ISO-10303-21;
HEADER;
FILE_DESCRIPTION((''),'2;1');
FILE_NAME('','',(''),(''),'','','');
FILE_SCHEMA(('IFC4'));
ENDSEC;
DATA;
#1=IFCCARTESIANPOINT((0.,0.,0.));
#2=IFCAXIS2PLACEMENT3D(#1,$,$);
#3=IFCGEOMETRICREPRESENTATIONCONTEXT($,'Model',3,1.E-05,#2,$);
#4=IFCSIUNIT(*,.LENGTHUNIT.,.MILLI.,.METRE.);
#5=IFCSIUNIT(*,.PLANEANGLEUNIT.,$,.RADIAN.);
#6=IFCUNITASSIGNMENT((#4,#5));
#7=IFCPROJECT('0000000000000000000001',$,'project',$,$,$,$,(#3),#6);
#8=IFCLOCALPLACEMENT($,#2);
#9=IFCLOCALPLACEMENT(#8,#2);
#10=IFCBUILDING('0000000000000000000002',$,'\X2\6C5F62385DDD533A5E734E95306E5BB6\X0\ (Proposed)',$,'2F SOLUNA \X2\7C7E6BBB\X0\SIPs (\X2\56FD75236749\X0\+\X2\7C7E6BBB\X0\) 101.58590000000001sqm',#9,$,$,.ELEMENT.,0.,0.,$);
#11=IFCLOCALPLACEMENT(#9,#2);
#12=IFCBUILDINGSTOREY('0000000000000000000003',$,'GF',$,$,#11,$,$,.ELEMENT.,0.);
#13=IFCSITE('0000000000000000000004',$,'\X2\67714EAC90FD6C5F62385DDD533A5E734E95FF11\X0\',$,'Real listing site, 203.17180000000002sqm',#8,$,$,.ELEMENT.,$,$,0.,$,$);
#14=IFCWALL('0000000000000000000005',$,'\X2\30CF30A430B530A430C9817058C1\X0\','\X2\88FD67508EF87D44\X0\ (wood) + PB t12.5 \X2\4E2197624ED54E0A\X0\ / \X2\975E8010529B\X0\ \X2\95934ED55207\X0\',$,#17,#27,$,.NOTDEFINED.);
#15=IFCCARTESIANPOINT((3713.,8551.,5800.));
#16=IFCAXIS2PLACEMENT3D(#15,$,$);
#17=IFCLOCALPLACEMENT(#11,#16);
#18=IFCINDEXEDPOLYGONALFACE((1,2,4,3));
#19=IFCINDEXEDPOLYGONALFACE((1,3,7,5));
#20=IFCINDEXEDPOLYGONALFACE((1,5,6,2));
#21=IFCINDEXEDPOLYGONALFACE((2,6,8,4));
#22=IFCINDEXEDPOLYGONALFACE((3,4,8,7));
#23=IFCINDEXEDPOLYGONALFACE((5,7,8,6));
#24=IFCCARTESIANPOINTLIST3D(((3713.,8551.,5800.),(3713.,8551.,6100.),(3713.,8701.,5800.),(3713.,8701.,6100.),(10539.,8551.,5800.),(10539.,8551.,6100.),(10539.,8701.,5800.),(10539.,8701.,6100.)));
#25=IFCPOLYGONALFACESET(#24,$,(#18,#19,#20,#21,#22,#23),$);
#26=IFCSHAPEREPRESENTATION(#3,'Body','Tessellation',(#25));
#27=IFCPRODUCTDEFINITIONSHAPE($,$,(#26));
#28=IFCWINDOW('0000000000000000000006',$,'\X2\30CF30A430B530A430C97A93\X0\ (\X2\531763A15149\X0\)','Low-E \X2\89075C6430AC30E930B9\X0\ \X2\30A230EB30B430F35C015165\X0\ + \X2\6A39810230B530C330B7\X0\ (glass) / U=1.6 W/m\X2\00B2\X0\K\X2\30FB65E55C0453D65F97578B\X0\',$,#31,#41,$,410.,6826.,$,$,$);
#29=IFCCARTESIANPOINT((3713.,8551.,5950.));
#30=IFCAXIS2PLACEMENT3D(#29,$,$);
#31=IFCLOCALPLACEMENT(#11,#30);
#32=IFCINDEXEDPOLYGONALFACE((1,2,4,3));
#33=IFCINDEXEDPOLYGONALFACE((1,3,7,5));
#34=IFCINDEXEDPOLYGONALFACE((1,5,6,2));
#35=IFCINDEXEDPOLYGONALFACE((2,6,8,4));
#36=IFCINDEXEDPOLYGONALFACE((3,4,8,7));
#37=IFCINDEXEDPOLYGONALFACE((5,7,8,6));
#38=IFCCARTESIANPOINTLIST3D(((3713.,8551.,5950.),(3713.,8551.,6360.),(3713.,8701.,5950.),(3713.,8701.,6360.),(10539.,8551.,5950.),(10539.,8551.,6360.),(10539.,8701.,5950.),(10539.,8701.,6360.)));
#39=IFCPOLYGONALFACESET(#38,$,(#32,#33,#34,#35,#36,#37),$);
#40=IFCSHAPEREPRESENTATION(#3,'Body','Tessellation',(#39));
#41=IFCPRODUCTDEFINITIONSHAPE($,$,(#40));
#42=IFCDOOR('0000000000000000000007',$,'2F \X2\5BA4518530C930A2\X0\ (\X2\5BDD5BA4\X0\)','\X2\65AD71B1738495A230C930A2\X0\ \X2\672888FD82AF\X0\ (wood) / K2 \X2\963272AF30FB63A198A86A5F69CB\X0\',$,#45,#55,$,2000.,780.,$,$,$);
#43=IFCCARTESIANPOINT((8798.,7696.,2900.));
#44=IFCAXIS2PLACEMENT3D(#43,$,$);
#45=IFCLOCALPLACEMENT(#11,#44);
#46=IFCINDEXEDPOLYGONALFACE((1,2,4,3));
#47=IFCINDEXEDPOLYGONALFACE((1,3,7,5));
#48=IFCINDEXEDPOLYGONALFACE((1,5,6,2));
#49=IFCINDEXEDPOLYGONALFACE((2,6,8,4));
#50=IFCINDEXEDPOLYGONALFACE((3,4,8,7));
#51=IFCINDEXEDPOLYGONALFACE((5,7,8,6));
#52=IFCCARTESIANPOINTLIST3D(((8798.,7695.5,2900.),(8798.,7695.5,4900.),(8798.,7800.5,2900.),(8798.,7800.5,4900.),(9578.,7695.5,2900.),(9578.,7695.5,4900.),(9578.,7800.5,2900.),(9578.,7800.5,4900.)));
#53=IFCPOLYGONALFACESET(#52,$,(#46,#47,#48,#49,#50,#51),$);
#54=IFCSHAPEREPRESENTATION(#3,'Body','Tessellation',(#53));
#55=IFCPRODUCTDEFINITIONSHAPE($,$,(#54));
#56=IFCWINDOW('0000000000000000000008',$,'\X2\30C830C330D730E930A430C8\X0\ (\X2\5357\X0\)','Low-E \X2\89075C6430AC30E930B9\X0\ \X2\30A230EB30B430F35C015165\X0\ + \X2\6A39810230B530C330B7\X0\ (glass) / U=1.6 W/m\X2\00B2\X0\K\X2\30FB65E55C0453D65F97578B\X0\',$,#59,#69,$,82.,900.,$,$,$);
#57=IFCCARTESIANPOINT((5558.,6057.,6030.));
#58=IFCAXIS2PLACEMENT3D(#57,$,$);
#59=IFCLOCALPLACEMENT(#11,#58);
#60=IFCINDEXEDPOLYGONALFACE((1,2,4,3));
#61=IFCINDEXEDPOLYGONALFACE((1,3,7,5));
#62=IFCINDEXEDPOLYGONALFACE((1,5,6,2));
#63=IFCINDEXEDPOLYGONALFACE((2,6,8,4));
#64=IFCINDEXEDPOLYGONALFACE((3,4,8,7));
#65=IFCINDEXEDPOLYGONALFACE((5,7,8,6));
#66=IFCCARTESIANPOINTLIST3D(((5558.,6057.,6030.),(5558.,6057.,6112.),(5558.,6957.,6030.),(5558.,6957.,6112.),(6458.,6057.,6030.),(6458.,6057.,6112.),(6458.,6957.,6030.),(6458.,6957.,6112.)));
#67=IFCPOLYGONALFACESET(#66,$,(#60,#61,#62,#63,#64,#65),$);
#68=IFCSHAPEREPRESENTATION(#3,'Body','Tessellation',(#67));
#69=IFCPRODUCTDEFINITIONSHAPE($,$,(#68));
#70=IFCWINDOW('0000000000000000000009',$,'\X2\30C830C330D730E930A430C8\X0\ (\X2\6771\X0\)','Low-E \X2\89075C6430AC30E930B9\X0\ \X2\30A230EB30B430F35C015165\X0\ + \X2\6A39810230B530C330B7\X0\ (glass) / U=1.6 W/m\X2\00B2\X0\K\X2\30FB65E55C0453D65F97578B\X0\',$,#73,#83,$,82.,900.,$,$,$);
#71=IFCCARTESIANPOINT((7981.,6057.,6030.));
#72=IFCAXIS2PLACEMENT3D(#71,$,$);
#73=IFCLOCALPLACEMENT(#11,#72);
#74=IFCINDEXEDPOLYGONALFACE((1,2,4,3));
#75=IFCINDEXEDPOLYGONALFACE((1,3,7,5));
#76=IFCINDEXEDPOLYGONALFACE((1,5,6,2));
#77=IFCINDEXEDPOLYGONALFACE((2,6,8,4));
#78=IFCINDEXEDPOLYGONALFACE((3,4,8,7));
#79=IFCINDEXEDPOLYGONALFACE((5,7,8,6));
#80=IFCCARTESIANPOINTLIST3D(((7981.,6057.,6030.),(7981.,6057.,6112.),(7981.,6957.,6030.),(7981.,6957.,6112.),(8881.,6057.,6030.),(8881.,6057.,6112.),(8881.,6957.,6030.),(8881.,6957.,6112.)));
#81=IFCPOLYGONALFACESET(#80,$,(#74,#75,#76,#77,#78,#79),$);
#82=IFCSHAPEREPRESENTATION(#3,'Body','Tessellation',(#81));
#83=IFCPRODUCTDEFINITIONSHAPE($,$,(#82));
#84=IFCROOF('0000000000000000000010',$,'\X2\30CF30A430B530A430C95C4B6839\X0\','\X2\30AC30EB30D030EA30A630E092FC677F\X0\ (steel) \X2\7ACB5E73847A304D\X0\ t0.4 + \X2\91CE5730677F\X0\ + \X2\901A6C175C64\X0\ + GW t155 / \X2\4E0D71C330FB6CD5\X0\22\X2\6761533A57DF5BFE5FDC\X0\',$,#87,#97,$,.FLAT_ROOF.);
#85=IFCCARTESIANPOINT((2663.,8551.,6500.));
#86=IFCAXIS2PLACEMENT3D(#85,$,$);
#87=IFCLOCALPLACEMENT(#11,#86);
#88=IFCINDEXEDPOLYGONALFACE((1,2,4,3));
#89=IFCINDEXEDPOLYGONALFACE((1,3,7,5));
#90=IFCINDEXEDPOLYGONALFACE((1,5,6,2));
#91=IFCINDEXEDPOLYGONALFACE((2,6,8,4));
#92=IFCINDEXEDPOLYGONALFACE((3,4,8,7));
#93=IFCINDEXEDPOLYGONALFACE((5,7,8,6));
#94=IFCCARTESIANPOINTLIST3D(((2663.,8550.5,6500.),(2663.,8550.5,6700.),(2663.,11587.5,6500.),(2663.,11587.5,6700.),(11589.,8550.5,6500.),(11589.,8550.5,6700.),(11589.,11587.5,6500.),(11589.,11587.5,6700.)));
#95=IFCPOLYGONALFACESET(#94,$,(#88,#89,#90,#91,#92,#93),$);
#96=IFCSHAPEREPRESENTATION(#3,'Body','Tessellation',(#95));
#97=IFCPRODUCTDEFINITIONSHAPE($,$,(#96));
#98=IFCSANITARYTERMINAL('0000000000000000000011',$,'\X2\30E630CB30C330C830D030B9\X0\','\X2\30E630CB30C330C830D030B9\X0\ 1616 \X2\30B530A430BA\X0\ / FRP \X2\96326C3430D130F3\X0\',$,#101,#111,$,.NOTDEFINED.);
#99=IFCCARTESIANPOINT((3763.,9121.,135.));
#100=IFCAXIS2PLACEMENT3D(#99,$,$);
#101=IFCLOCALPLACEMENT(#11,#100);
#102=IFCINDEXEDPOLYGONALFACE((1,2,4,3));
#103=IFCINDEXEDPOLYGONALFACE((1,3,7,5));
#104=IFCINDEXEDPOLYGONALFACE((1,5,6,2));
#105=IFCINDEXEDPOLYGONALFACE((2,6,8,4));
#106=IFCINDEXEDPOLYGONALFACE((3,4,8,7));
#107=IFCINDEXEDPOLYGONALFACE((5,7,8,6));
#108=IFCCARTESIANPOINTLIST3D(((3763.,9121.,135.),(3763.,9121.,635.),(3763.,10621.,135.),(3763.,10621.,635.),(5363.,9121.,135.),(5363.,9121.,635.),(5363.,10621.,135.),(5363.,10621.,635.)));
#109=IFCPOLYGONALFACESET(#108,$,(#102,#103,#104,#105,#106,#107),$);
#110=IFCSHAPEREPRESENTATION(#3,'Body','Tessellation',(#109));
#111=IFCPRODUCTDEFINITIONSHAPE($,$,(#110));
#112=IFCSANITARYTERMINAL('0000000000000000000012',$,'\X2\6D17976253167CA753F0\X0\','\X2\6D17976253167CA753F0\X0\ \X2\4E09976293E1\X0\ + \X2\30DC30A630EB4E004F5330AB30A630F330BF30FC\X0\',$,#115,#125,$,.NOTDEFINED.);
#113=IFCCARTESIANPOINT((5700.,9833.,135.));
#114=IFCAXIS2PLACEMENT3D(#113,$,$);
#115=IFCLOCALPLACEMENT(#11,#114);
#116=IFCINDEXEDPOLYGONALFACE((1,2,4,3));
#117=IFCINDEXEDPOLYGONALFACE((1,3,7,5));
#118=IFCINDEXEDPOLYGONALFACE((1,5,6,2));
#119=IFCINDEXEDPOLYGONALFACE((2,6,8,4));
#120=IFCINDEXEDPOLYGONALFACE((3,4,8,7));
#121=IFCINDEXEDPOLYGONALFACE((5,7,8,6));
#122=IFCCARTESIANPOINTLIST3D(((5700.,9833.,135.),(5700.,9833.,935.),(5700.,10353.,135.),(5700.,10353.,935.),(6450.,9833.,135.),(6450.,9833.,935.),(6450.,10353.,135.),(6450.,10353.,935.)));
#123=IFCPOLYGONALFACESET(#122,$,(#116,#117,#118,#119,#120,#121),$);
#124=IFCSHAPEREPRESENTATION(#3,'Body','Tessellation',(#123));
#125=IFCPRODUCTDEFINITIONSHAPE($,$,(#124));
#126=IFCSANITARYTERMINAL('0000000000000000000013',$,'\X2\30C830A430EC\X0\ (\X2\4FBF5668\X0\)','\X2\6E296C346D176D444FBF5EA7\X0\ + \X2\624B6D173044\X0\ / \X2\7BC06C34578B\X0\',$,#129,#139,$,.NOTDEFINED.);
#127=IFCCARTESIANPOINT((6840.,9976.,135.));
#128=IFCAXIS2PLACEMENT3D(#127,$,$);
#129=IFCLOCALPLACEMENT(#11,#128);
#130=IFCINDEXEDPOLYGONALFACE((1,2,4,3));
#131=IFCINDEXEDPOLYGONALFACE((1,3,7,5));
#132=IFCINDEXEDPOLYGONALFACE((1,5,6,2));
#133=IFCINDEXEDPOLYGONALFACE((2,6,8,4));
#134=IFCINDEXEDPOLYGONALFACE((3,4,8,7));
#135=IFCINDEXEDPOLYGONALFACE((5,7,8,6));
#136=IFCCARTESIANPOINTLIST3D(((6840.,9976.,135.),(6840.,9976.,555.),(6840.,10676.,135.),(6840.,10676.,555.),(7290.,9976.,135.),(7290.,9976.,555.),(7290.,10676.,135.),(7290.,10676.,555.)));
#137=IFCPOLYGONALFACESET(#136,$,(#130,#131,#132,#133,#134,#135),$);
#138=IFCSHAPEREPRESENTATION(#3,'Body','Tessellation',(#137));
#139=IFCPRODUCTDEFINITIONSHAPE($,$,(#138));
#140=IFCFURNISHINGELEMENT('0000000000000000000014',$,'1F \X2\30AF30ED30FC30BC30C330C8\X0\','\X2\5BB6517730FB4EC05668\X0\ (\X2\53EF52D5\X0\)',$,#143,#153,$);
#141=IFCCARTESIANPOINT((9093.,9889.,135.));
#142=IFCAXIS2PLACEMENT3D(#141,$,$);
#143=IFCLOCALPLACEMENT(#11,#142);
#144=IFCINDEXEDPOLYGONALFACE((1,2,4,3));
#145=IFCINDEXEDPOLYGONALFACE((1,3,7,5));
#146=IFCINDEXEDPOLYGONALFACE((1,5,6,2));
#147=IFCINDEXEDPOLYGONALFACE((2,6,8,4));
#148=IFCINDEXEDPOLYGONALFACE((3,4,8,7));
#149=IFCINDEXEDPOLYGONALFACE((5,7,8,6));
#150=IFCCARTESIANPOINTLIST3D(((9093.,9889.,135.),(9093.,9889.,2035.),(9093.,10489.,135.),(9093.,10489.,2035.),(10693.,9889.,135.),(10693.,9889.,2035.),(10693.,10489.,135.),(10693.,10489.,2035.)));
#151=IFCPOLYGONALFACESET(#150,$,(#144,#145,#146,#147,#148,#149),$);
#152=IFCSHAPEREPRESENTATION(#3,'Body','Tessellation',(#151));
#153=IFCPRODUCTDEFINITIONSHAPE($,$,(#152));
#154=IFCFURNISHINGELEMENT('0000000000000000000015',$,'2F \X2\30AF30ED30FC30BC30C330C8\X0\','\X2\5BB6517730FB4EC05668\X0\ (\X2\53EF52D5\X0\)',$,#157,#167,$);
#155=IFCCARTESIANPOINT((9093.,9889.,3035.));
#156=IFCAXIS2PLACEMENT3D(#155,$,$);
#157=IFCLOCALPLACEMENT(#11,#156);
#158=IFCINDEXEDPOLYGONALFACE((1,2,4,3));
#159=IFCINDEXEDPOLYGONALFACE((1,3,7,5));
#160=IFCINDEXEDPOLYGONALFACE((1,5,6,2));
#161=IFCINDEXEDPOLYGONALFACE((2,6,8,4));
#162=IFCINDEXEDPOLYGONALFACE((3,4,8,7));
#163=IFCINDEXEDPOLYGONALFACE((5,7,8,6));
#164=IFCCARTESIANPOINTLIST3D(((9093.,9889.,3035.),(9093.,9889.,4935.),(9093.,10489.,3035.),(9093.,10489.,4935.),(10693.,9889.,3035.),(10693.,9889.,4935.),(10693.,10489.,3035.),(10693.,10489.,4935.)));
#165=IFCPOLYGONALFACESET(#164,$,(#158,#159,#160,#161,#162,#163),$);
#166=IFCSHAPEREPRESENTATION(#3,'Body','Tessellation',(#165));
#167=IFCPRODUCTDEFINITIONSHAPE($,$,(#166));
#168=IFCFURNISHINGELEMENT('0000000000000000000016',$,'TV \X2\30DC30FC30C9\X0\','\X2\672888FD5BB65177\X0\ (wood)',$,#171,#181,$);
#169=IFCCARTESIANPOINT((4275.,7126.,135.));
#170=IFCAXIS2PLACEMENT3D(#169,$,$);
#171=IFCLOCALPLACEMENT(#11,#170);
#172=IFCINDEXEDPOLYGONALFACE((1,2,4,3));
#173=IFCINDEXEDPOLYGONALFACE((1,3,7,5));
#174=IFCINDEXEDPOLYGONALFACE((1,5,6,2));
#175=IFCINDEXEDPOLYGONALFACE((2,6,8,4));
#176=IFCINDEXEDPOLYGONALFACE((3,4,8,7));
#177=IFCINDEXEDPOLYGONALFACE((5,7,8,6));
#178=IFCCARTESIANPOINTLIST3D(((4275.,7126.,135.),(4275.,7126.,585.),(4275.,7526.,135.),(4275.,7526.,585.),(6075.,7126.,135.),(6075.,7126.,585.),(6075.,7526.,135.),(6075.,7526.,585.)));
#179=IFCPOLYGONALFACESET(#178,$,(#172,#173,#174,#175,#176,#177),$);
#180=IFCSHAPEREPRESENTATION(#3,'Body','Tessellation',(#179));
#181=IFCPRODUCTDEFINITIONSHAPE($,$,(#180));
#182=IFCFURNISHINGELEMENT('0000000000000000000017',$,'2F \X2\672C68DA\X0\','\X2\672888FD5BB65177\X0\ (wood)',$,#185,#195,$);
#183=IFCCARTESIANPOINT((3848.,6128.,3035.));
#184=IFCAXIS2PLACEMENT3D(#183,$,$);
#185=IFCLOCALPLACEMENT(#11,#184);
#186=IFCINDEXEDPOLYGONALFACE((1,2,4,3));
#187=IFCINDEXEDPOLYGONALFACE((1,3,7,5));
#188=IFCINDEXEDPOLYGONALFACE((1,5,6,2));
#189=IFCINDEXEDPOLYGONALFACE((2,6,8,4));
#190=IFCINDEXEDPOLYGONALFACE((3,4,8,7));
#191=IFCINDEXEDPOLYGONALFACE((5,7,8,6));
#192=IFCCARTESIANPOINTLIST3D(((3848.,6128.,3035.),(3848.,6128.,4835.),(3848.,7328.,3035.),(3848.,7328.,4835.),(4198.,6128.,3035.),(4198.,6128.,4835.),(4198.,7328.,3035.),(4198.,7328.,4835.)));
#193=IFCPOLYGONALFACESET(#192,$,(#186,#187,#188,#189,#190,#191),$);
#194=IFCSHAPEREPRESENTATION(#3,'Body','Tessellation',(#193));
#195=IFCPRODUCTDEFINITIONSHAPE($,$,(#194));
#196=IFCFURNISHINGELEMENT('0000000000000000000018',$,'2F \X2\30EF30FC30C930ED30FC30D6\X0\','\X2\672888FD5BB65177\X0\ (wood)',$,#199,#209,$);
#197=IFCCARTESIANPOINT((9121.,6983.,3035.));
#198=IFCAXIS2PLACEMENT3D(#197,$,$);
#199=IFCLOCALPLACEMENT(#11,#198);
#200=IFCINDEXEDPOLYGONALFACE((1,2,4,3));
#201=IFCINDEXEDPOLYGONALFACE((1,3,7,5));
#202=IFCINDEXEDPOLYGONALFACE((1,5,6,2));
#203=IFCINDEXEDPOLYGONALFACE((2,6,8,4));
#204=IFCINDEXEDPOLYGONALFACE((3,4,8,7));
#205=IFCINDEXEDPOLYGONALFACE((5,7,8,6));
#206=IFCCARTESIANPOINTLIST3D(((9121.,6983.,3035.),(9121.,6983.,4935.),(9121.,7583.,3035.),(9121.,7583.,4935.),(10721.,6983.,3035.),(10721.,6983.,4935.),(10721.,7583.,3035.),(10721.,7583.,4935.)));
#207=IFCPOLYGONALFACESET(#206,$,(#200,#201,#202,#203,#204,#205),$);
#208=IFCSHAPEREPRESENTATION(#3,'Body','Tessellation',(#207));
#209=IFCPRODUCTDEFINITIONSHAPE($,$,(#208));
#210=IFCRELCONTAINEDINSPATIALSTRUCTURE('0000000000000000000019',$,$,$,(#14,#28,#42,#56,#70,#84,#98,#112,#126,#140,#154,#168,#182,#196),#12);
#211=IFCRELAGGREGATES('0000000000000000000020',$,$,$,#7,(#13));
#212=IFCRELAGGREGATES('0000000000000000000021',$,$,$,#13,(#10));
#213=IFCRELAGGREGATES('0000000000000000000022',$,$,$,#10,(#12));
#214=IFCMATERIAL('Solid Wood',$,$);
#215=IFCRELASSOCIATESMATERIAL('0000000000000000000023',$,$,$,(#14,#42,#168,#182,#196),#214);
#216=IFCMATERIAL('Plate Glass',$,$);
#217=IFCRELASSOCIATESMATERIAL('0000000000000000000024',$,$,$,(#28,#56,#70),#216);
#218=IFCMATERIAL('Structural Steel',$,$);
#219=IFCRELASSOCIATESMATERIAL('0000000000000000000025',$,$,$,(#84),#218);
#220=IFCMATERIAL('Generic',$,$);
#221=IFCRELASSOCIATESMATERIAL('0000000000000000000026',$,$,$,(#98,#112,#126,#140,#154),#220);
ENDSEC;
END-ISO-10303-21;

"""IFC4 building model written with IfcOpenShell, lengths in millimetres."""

from ifc_helpers import new_model, si_unit, frame, frame_2d, origin, place, context, project, spatial, rectangle, extrude, material, element, fill, save


model = new_model("IFC4")

# Units and contexts
model_context = context("Model", 3, precision=1e-05, world=origin())
ifc_project = project(units=[si_unit("LENGTHUNIT", "METRE", prefix="MILLI"), si_unit("PLANEANGLEUNIT", "RADIAN")], contexts=[model_context])

# Site, building, storey
site_placement = place(None, origin())
site = spatial("IfcSite", under=ifc_project, at=site_placement, Name="東京都江戸川区平井１", ObjectType="Real listing site, 203.17180000000002sqm", CompositionType="ELEMENT", RefElevation=0.0)
building_placement = place(site_placement, origin())
building = spatial("IfcBuilding", under=site, at=building_placement, Name="江戸川区平井の家 (Proposed)", ObjectType="2F SOLUNA 籾殻SIPs (国産杉+籾殻) 101.58590000000001sqm", CompositionType="ELEMENT", ElevationOfRefHeight=0.0, ElevationOfTerrain=0.0)
storey_placement = place(building_placement, origin())
storey = spatial("IfcBuildingStorey", under=building, at=storey_placement, Name="GF", CompositionType="ELEMENT", Elevation=0.0)

# Shared definitions
ifc_material_1 = material(Name="Solid Wood")
ifc_material_2 = material(Name="Plate Glass")

# Wall, opening, window
wall_1_placement = place(storey_placement, frame((3713.0, 8551.0, 5800.0)))
wall_1 = element("IfcWall", 1, at=wall_1_placement, inside=storey, material=ifc_material_1, Name="ハイサイド腰壁", Description="製材軸組 (wood) + PB t12.5 両面仕上 / 非耐力 間仕切", PredefinedType="NOTDEFINED", context=model_context, shape_type="SweptSolid", body=[
    extrude(rectangle(XDim=6826.0, YDim=150.0, at=frame_2d((3413.0, 75.0))), frame((3713.0, 8551.0, 5800.0)), (0.0, 0.0, 1.0), 700.0),
])
opening_1_placement = place(storey_placement, frame((3713.0, 8551.0, 5950.0)))
opening_1 = element("IfcOpeningElement", 2, at=opening_1_placement, cuts=wall_1, PredefinedType="NOTDEFINED", context=model_context, shape_type="SweptSolid", body=[
    extrude(rectangle(XDim=6826.0, YDim=150.0, at=frame_2d((3413.0, 75.0))), frame((3713.0, 8551.0, 5950.0)), (0.0, 0.0, 1.0), 410.0),
])
window_1_placement = place(storey_placement, frame((3713.0, 8551.0, 5950.0)))
window_1 = element("IfcWindow", 3, at=window_1_placement, inside=storey, material=ifc_material_2, Name="ハイサイド窓 (北採光)", Description="Low-E 複層ガラス アルゴン封入 + 樹脂サッシ (glass) / U=1.6 W/m²K・日射取得型", OverallHeight=410.0, OverallWidth=6826.0, context=model_context, shape_type="SweptSolid", body=[
    extrude(rectangle(XDim=6826.0, YDim=150.0, at=frame_2d((3413.0, 75.0))), frame((3713.0, 8551.0, 5950.0)), (0.0, 0.0, 1.0), 410.0),
])
fill(opening_1, window_1)

# Door
door_1_placement = place(storey_placement, frame((8798.0, 7696.0, 2900.0)))
element("IfcDoor", 4, at=door_1_placement, inside=storey, material=ifc_material_1, Name="2F 室内ドア (寝室)", Description="断熱玄関ドア 木製芯 (wood) / K2 防犯・採風機構", OverallHeight=2000.0, OverallWidth=780.0, context=model_context, shape_type="SweptSolid", body=[
    extrude(rectangle(XDim=780.0, YDim=105.0, at=frame_2d((390.0, 52.0))), frame((8798.0, 7696.0, 2900.0)), (0.0, 0.0, 1.0), 2000.0),
])

# Windows
window_2_placement = place(storey_placement, frame((5558.0, 6057.0, 6030.0)))
element("IfcWindow", 5, at=window_2_placement, inside=storey, material=ifc_material_2, Name="トップライト (南)", Description="Low-E 複層ガラス アルゴン封入 + 樹脂サッシ (glass) / U=1.6 W/m²K・日射取得型", OverallHeight=82.0, OverallWidth=900.0, context=model_context, shape_type="SweptSolid", body=[
    extrude(rectangle(XDim=900.0, YDim=900.0, at=frame_2d((450.0, 450.0))), frame((5558.0, 6057.0, 6030.0)), (0.0, 0.0, 1.0), 82.0),
])
window_3_placement = place(storey_placement, frame((7981.0, 6057.0, 6030.0)))
element("IfcWindow", 6, at=window_3_placement, inside=storey, material=ifc_material_2, Name="トップライト (東)", Description="Low-E 複層ガラス アルゴン封入 + 樹脂サッシ (glass) / U=1.6 W/m²K・日射取得型", OverallHeight=82.0, OverallWidth=900.0, context=model_context, shape_type="SweptSolid", body=[
    extrude(rectangle(XDim=900.0, YDim=900.0, at=frame_2d((450.0, 450.0))), frame((7981.0, 6057.0, 6030.0)), (0.0, 0.0, 1.0), 82.0),
])

# Roof
ifc_material_3 = material(Name="Structural Steel")
roof_placement = place(storey_placement, frame((2663.0, 8551.0, 6500.0)))
element("IfcRoof", 7, at=roof_placement, inside=storey, material=ifc_material_3, Name="ハイサイド屋根", Description="ガルバリウム鋼板 (steel) 立平葺き t0.4 + 野地板 + 通気層 + GW t155 / 不燃・法22条区域対応", PredefinedType="FLAT_ROOF", context=model_context, shape_type="SweptSolid", body=[
    extrude(rectangle(XDim=8926.0, YDim=3037.0, at=frame_2d((4463.0, 1518.0))), frame((2663.0, 8551.0, 6500.0)), (0.0, 0.0, 1.0), 200.0),
])

# Sanitary terminals
ifc_material_4 = material(Name="Generic")
sanitary_terminal_1_placement = place(storey_placement, frame((3763.0, 9121.0, 135.0)))
element("IfcSanitaryTerminal", 8, at=sanitary_terminal_1_placement, inside=storey, material=ifc_material_4, Name="ユニットバス", Description="ユニットバス 1616 サイズ / FRP 防水パン", PredefinedType="NOTDEFINED", context=model_context, shape_type="SweptSolid", body=[
    extrude(rectangle(XDim=1600.0, YDim=1500.0, at=frame_2d((800.0, 750.0))), frame((3763.0, 9121.0, 135.0)), (0.0, 0.0, 1.0), 500.0),
])
sanitary_terminal_2_placement = place(storey_placement, frame((5700.0, 9833.0, 135.0)))
element("IfcSanitaryTerminal", 9, at=sanitary_terminal_2_placement, inside=storey, material=ifc_material_4, Name="洗面化粧台", Description="洗面化粧台 三面鏡 + ボウル一体カウンター", PredefinedType="NOTDEFINED", context=model_context, shape_type="SweptSolid", body=[
    extrude(rectangle(XDim=750.0, YDim=520.0, at=frame_2d((375.0, 260.0))), frame((5700.0, 9833.0, 135.0)), (0.0, 0.0, 1.0), 800.0),
])
sanitary_terminal_3_placement = place(storey_placement, frame((6840.0, 9976.0, 135.0)))
element("IfcSanitaryTerminal", 10, at=sanitary_terminal_3_placement, inside=storey, material=ifc_material_4, Name="トイレ (便器)", Description="温水洗浄便座 + 手洗い / 節水型", PredefinedType="NOTDEFINED", context=model_context, shape_type="SweptSolid", body=[
    extrude(rectangle(XDim=450.0, YDim=700.0, at=frame_2d((225.0, 350.0))), frame((6840.0, 9976.0, 135.0)), (0.0, 0.0, 1.0), 420.0),
])

# Furnishing elements
furnishing_1_placement = place(storey_placement, frame((9093.0, 9889.0, 135.0)))
element("IfcFurnishingElement", 11, at=furnishing_1_placement, inside=storey, material=ifc_material_4, Name="1F クローゼット", Description="家具・什器 (可動)", context=model_context, shape_type="SweptSolid", body=[
    extrude(rectangle(XDim=1600.0, YDim=600.0, at=frame_2d((800.0, 300.0))), frame((9093.0, 9889.0, 135.0)), (0.0, 0.0, 1.0), 1900.0),
])
furnishing_2_placement = place(storey_placement, frame((9093.0, 9889.0, 3035.0)))
element("IfcFurnishingElement", 12, at=furnishing_2_placement, inside=storey, material=ifc_material_4, Name="2F クローゼット", Description="家具・什器 (可動)", context=model_context, shape_type="SweptSolid", body=[
    extrude(rectangle(XDim=1600.0, YDim=600.0, at=frame_2d((800.0, 300.0))), frame((9093.0, 9889.0, 3035.0)), (0.0, 0.0, 1.0), 1900.0),
])
furnishing_3_placement = place(storey_placement, frame((4275.0, 7126.0, 135.0)))
element("IfcFurnishingElement", 13, at=furnishing_3_placement, inside=storey, material=ifc_material_1, Name="TV ボード", Description="木製家具 (wood)", context=model_context, shape_type="SweptSolid", body=[
    extrude(rectangle(XDim=1800.0, YDim=400.0, at=frame_2d((900.0, 200.0))), frame((4275.0, 7126.0, 135.0)), (0.0, 0.0, 1.0), 450.0),
])
furnishing_4_placement = place(storey_placement, frame((3848.0, 6128.0, 3035.0)))
element("IfcFurnishingElement", 14, at=furnishing_4_placement, inside=storey, material=ifc_material_1, Name="2F 本棚", Description="木製家具 (wood)", context=model_context, shape_type="SweptSolid", body=[
    extrude(rectangle(XDim=350.0, YDim=1200.0, at=frame_2d((175.0, 600.0))), frame((3848.0, 6128.0, 3035.0)), (0.0, 0.0, 1.0), 1800.0),
])
furnishing_5_placement = place(storey_placement, frame((9121.0, 6983.0, 3035.0)))
element("IfcFurnishingElement", 15, at=furnishing_5_placement, inside=storey, material=ifc_material_1, Name="2F ワードローブ", Description="木製家具 (wood)", context=model_context, shape_type="SweptSolid", body=[
    extrude(rectangle(XDim=1600.0, YDim=600.0, at=frame_2d((800.0, 300.0))), frame((9121.0, 6983.0, 3035.0)), (0.0, 0.0, 1.0), 1900.0),
])

save(model, "model.ifc")
